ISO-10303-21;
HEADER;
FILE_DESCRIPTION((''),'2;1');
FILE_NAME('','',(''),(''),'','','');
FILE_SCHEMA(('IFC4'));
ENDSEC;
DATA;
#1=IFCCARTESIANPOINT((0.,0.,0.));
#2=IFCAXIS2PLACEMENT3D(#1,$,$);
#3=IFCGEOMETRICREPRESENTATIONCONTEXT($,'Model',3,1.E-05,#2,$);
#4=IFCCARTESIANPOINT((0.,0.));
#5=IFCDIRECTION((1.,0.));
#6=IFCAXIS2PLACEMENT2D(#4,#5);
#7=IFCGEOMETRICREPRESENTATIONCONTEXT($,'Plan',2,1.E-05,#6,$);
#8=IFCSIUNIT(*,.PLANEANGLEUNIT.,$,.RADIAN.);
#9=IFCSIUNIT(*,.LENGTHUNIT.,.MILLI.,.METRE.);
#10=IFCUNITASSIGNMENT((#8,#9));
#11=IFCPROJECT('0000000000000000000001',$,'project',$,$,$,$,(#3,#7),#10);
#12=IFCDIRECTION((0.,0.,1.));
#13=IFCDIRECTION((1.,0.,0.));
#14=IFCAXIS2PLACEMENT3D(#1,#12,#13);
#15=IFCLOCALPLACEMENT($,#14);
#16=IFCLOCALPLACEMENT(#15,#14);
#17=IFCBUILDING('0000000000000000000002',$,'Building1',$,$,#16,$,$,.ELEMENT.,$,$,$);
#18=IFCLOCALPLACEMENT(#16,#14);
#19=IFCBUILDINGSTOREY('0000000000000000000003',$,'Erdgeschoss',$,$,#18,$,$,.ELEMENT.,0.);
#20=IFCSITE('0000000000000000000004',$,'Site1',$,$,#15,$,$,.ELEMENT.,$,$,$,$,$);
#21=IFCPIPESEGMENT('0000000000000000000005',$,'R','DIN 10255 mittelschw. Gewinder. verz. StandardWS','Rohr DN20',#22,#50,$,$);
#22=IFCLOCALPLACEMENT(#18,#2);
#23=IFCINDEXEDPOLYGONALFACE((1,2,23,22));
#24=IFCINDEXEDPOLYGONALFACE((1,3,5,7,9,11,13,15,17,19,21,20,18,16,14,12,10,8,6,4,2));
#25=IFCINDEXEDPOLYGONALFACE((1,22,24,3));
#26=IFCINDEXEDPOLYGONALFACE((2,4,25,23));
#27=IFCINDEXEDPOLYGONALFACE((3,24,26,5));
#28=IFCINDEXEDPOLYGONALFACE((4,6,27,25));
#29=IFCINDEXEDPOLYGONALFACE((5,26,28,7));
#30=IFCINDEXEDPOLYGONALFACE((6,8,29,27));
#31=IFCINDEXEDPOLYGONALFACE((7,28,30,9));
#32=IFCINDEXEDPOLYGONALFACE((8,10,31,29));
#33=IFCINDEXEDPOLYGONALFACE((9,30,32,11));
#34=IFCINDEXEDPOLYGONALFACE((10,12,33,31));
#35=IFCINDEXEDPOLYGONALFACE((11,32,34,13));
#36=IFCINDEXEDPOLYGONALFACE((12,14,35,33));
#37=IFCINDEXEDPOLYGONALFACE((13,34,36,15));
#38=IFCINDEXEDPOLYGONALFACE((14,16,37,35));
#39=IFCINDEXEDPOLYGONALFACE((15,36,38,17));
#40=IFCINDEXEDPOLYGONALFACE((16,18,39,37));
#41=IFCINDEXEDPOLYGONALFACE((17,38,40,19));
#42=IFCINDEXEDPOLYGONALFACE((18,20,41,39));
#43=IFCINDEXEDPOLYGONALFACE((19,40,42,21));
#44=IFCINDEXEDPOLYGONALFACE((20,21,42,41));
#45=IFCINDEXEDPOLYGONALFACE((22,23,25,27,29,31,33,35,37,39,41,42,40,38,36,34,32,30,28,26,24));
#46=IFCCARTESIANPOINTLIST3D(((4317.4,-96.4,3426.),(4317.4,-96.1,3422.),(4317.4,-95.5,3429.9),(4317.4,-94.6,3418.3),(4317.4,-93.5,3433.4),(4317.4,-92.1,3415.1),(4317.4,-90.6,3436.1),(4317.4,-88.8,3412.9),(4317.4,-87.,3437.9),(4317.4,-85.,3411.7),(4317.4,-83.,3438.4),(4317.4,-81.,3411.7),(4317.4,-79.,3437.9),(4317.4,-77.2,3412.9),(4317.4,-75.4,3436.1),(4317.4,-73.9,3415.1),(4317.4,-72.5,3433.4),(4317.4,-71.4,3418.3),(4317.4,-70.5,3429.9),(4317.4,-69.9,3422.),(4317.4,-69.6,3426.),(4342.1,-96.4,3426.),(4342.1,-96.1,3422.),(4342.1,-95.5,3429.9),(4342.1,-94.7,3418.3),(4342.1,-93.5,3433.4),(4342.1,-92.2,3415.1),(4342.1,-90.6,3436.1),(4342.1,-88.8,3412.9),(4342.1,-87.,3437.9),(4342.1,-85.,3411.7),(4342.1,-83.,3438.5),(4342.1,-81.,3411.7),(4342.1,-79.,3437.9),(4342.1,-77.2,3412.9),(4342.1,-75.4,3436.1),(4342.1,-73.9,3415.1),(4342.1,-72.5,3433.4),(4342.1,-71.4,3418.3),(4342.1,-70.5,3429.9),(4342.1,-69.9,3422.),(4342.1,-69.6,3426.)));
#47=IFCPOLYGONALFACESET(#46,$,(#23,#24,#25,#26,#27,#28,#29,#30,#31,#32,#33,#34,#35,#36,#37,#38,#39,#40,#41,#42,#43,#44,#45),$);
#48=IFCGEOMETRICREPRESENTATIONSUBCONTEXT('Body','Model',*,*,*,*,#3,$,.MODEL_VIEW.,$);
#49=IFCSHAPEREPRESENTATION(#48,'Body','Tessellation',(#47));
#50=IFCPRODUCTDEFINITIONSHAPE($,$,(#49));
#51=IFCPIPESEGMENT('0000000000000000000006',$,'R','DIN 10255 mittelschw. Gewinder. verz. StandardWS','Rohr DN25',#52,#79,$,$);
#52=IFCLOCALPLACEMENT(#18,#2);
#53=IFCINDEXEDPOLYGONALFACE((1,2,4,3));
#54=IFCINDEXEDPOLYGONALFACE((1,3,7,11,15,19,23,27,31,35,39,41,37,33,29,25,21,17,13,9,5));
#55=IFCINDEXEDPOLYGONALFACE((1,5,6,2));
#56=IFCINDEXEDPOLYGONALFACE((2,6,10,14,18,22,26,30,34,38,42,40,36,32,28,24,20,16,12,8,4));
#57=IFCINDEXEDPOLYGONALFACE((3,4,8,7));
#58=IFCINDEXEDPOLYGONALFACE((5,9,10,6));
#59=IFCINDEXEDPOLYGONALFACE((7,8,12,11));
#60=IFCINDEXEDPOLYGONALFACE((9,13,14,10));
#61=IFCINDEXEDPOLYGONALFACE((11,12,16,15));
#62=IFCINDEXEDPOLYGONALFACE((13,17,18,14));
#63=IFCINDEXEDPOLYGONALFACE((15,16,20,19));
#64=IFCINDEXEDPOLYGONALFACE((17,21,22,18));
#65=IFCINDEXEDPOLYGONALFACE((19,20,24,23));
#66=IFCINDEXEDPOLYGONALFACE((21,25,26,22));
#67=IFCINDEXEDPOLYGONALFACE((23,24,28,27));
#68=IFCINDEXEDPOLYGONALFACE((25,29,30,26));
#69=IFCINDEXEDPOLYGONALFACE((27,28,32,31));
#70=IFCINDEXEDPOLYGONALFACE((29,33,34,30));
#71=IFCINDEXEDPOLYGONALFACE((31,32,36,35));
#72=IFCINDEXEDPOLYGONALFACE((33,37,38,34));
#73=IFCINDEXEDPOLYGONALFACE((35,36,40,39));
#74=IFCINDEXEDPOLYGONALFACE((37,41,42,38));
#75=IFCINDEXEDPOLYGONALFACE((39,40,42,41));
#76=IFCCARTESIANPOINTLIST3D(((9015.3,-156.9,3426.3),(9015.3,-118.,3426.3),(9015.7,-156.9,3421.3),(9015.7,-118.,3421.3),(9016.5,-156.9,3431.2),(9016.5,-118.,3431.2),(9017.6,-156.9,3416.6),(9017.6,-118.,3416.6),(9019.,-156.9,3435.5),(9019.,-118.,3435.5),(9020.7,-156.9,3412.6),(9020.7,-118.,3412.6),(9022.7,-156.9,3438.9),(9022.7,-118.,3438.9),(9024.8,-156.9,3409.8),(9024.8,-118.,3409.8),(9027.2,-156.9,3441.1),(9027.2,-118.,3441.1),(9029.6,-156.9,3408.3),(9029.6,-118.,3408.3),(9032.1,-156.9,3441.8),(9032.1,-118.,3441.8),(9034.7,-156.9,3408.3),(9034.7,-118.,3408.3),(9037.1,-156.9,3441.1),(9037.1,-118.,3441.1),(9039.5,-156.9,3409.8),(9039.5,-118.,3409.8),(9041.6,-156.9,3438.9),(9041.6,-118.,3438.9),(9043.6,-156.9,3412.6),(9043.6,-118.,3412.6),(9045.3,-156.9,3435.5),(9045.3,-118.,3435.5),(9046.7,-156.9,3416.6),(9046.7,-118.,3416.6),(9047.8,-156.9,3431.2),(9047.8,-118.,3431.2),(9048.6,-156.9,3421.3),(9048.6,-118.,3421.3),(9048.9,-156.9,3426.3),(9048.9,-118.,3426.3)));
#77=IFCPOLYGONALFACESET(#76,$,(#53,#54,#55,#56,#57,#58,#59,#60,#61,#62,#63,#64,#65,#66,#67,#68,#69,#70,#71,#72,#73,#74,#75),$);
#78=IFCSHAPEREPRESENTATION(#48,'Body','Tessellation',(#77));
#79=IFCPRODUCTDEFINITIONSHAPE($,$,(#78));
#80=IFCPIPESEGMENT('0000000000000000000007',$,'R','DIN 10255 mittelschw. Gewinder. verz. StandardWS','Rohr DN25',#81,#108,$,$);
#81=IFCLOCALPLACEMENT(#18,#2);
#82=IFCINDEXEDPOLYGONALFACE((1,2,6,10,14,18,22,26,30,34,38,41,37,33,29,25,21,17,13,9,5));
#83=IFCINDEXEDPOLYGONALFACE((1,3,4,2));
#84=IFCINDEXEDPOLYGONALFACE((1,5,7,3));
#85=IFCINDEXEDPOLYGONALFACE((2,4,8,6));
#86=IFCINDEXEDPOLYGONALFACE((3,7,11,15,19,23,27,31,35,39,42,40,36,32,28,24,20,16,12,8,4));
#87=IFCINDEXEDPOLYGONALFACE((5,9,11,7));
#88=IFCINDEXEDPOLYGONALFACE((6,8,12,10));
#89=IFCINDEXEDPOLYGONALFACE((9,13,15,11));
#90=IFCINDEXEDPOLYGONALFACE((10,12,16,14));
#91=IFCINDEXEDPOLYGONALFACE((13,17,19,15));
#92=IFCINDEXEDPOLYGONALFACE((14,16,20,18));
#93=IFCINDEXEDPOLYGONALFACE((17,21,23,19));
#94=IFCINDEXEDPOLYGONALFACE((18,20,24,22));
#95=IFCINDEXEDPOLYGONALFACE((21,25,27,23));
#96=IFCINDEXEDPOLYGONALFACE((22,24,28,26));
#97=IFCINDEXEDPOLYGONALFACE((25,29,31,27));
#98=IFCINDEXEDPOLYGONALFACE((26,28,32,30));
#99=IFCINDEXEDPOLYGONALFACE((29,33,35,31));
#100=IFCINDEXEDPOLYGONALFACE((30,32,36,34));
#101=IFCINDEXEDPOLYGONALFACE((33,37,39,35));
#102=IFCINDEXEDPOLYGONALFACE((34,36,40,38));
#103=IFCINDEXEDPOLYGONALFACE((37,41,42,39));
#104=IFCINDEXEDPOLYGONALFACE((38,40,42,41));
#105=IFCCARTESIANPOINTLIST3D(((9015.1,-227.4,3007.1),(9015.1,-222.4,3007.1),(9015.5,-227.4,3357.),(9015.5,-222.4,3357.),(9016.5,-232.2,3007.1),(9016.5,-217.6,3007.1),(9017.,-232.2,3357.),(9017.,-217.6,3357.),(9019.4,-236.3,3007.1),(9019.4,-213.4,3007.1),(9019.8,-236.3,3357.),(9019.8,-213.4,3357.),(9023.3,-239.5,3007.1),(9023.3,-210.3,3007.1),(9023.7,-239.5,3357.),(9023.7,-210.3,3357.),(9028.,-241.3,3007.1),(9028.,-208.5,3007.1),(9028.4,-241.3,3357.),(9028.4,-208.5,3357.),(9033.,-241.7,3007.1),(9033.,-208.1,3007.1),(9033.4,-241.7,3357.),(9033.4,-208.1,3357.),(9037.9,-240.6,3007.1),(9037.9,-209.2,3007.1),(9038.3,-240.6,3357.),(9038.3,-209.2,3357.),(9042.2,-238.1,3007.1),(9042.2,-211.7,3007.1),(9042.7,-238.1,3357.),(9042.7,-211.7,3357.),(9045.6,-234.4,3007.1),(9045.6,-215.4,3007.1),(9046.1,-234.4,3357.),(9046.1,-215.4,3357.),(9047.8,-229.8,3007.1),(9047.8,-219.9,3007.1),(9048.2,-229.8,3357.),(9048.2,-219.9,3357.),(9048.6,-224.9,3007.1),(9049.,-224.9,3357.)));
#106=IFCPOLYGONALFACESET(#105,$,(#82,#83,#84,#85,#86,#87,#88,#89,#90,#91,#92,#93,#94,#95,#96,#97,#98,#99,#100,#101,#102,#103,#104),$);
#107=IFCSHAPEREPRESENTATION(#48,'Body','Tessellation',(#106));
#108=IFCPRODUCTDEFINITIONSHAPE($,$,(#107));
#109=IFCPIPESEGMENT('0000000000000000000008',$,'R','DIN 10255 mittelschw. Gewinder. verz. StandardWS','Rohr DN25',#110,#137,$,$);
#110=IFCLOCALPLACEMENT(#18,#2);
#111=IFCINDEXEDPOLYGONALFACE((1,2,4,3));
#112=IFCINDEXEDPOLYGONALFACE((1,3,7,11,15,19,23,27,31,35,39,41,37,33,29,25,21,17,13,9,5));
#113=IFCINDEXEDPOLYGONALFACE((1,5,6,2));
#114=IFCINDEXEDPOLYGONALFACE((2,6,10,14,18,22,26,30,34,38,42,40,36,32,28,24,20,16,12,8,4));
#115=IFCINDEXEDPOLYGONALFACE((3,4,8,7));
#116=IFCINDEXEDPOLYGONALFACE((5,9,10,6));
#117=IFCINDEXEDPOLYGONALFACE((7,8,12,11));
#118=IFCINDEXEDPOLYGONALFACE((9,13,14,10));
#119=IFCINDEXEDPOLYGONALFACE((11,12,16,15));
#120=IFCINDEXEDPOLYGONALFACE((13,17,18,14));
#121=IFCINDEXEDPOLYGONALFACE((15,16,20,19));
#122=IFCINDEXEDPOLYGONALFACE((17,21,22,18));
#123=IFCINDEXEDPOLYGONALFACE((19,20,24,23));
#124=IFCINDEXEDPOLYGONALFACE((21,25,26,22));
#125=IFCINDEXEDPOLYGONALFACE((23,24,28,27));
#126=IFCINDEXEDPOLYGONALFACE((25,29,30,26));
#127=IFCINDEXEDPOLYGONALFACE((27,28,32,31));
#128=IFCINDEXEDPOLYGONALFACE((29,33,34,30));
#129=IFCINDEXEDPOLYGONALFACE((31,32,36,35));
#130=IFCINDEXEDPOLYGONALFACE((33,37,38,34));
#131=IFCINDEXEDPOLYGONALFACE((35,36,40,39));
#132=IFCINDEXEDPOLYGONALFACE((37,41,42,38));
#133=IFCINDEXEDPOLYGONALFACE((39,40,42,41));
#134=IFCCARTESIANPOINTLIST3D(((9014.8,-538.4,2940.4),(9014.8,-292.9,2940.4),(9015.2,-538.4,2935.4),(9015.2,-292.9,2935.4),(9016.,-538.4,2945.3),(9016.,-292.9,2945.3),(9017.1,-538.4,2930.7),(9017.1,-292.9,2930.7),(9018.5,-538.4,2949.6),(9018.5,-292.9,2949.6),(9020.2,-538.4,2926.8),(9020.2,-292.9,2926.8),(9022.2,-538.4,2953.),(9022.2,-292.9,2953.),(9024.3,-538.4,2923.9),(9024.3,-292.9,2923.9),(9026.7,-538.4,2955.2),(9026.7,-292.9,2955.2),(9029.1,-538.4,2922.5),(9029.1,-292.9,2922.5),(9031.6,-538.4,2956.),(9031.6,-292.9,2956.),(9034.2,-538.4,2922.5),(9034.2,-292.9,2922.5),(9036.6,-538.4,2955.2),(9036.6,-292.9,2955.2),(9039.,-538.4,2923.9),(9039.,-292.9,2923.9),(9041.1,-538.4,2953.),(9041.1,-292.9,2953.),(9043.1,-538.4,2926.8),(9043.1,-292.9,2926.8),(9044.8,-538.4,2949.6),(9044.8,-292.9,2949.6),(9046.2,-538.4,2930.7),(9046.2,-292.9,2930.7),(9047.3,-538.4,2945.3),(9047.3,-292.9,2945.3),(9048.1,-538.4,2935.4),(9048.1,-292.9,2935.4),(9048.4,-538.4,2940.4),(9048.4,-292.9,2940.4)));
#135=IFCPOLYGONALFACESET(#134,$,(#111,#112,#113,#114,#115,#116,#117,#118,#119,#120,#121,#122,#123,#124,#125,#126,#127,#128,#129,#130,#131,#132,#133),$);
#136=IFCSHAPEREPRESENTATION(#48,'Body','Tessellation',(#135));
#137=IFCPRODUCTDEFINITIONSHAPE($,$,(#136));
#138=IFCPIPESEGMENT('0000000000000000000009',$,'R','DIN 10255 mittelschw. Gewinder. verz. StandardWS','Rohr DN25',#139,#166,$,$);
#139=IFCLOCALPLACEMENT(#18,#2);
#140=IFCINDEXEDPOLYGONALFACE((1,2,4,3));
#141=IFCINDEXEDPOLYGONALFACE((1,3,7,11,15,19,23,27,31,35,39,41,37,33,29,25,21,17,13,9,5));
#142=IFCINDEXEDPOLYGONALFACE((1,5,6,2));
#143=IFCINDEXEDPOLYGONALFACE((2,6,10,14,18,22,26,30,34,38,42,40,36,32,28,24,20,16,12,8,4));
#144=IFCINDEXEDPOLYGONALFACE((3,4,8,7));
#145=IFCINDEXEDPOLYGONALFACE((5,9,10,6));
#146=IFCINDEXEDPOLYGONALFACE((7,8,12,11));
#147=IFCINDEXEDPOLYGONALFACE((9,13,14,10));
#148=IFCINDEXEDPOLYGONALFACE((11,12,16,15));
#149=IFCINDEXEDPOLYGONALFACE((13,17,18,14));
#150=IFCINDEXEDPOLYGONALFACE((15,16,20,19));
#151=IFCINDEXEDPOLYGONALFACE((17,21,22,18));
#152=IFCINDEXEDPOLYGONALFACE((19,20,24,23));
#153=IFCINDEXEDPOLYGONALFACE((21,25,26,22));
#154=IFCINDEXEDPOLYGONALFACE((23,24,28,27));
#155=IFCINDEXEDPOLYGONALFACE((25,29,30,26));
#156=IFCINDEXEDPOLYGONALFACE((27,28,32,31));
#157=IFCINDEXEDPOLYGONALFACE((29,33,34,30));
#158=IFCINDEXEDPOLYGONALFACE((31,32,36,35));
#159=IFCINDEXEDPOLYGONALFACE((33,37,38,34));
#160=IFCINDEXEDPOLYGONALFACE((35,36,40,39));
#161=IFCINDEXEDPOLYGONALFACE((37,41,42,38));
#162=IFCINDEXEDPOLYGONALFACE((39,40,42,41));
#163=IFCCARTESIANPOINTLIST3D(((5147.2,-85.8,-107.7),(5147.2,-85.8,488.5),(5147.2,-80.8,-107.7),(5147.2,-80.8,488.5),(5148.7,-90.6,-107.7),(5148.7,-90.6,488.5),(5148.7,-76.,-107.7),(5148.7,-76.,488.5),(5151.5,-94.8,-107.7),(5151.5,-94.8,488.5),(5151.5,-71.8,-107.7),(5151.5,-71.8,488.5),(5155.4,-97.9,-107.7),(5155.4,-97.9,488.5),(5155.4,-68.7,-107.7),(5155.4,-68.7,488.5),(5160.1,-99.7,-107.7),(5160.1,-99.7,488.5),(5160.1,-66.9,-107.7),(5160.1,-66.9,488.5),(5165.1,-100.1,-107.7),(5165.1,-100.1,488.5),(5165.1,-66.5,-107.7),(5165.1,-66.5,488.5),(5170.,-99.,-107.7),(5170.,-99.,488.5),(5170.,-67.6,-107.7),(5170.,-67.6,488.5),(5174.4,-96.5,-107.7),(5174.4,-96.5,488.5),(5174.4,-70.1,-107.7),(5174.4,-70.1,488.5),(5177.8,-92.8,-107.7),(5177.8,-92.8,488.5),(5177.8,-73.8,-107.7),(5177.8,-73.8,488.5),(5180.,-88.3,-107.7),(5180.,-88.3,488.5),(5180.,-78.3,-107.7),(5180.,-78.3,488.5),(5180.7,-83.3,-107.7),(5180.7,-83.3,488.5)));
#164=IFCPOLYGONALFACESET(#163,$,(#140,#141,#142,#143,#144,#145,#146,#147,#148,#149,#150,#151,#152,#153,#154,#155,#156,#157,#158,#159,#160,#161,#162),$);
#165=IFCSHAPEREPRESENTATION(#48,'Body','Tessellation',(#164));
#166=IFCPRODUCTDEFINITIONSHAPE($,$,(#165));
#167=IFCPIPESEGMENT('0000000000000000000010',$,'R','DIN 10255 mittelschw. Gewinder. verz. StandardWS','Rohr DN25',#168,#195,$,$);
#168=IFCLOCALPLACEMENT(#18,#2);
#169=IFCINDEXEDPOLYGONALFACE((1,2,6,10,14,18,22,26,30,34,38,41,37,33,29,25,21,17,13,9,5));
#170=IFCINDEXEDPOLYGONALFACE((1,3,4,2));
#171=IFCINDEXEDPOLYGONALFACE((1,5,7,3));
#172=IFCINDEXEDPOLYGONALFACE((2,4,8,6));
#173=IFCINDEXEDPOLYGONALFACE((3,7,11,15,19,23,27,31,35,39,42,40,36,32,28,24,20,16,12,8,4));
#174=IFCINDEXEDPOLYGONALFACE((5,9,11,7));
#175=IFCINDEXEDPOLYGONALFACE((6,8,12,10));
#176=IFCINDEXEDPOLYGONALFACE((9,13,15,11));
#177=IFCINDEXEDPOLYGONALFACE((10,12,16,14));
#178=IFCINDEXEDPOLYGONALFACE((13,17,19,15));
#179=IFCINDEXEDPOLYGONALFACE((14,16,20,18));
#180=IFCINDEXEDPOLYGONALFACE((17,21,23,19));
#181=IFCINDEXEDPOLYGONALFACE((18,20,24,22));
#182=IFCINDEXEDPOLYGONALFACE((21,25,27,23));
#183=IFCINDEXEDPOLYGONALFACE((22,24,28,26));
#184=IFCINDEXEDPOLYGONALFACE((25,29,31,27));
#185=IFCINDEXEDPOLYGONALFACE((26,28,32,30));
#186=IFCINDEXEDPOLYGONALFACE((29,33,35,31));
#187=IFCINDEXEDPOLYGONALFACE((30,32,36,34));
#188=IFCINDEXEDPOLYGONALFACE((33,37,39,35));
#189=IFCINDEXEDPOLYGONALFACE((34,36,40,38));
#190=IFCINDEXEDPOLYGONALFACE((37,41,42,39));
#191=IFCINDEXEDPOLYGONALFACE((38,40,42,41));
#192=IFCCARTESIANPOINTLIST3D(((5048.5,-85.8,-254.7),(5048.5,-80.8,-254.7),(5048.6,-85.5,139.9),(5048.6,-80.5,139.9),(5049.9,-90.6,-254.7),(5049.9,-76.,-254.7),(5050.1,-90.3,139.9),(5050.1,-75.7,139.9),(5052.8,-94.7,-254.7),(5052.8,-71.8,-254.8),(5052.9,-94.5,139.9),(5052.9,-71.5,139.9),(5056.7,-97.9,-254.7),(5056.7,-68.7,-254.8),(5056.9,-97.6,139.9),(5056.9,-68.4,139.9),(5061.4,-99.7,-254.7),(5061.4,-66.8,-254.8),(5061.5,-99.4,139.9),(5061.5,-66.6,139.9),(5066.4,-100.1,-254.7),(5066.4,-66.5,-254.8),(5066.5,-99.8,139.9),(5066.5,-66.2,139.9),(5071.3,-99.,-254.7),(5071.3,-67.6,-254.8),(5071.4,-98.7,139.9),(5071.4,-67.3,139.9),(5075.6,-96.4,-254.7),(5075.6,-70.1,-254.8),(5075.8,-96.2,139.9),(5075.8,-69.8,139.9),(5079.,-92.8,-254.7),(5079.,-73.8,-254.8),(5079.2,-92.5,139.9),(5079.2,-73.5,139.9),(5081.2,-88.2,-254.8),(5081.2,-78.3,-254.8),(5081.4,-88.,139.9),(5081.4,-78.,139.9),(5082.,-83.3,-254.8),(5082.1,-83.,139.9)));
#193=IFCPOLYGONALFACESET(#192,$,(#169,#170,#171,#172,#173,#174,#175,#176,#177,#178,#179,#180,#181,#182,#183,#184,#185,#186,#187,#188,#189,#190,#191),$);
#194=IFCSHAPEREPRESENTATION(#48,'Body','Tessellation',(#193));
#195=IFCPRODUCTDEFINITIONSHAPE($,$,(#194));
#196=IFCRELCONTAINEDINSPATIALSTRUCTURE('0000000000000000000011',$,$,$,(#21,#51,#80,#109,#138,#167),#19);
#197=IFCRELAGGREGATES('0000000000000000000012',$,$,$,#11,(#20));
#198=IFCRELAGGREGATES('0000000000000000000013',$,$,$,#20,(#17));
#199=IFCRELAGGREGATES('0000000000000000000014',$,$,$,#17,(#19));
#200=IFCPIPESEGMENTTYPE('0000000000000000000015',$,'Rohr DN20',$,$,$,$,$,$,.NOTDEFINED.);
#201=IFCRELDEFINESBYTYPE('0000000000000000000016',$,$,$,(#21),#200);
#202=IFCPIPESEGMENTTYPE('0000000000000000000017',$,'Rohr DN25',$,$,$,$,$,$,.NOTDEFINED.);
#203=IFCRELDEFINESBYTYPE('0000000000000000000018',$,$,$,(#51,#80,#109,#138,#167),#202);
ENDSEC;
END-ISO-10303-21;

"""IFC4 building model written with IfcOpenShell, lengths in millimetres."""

from ifc_helpers import new_model, si_unit, frame, origin, origin_with_axes, origin_2d_with_axis, place, context, subcontext, project, spatial, circle, extrude, type_object, element, save


model = new_model("IFC4")

# Units and contexts
model_context = context("Model", 3, precision=1e-05, world=origin())
plan_context = context("Plan", 2, precision=1e-05, world=origin_2d_with_axis())
body_context = subcontext(model_context, "Body", "Model", "MODEL_VIEW")
ifc_project = project(units=[si_unit("PLANEANGLEUNIT", "RADIAN"), si_unit("LENGTHUNIT", "METRE", prefix="MILLI")], contexts=[model_context, plan_context])

# Site, building, storey
site_placement = place(None, origin_with_axes())
site = spatial("IfcSite", under=ifc_project, at=site_placement, Name="Site1", CompositionType="ELEMENT")
building_placement = place(site_placement, origin_with_axes())
building = spatial("IfcBuilding", under=site, at=building_placement, Name="Building1", CompositionType="ELEMENT")
storey_placement = place(building_placement, origin_with_axes())
storey = spatial("IfcBuildingStorey", under=building, at=storey_placement, Name="Erdgeschoss", CompositionType="ELEMENT", Elevation=0.0)

# Pipe segments
pipe_segment_type_1 = type_object("IfcPipeSegmentType", Name="Rohr DN20", PredefinedType="NOTDEFINED")
pipe_segment_1_placement = place(storey_placement, frame((4329.7, -83.2, 3425.0), z_axis=(0.0, 0.0, 1.0), x_axis=(1.0, 0.0, 0.0)))
element("IfcPipeSegment", 1, at=pipe_segment_1_placement, inside=storey, type_object=pipe_segment_type_1, Name="R", Description="DIN 10255 mittelschw. Gewinder. verz. StandardWS", ObjectType="Rohr DN20", context=body_context, shape_type="SolidModel", body=[
    extrude(circle(Radius=13.4, at=origin_2d_with_axis()), frame((12.3, 0.1, 0.0), z_axis=(-1.0, 0.000133, -0.000096), x_axis=(0.0, 0.0, 1.0)), (0.0, 0.0, 1.0), 24.7),
])
pipe_segment_type_2 = type_object("IfcPipeSegmentType", Name="Rohr DN25", PredefinedType="NOTDEFINED")
pipe_segment_2_placement = place(storey_placement, frame((9032.3, -137.4, 3425.0), z_axis=(0.0, 0.0, 1.0), x_axis=(1.0, 0.0, 0.0)))
element("IfcPipeSegment", 2, at=pipe_segment_2_placement, inside=storey, type_object=pipe_segment_type_2, Name="R", Description="DIN 10255 mittelschw. Gewinder. verz. StandardWS", ObjectType="Rohr DN25", context=body_context, shape_type="SolidModel", body=[
    extrude(circle(Radius=16.9, at=origin_2d_with_axis()), frame((-0.1, 19.4, 0.0), z_axis=(0.0, -1.0, 0.0), x_axis=(0.0, 0.0, 1.0)), (0.0, 0.0, 1.0), 38.9),
])
pipe_segment_3_placement = place(storey_placement, frame((9031.9, -225.0, 3182.1), z_axis=(0.0, 0.0, 1.0), x_axis=(1.0, 0.0, 0.0)))
element("IfcPipeSegment", 3, at=pipe_segment_3_placement, inside=storey, type_object=pipe_segment_type_2, Name="R", Description="DIN 10255 mittelschw. Gewinder. verz. StandardWS", ObjectType="Rohr DN25", context=body_context, shape_type="SolidModel", body=[
    extrude(circle(Radius=16.9, at=origin_2d_with_axis()), frame((0.2, 0.2, 174.9), z_axis=(-0.001207, 0.0, -0.999999), x_axis=(1.0, 0.0, 0.0)), (0.0, 0.0, 1.0), 349.9),
])
pipe_segment_4_placement = place(storey_placement, frame((9031.5, -415.6, 2939.1), z_axis=(0.0, 0.0, 1.0), x_axis=(1.0, 0.0, 0.0)))
element("IfcPipeSegment", 4, at=pipe_segment_4_placement, inside=storey, type_object=pipe_segment_type_2, Name="R", Description="DIN 10255 mittelschw. Gewinder. verz. StandardWS", ObjectType="Rohr DN25", context=body_context, shape_type="SolidModel", body=[
    extrude(circle(Radius=16.9, at=origin_2d_with_axis()), frame((0.1, -122.8, 0.0), z_axis=(0.0, 1.0, 0.0), x_axis=(0.0, 0.0, 1.0)), (0.0, 0.0, 1.0), 245.5),
])
pipe_segment_5_placement = place(storey_placement, frame((5163.9, -83.4, 190.4), z_axis=(0.0, 0.0, 1.0), x_axis=(1.0, 0.0, 0.0)))
element("IfcPipeSegment", 5, at=pipe_segment_5_placement, inside=storey, type_object=pipe_segment_type_2, Name="R", Description="DIN 10255 mittelschw. Gewinder. verz. StandardWS", ObjectType="Rohr DN25", context=body_context, shape_type="SolidModel", body=[
    extrude(circle(Radius=16.9, at=origin_2d_with_axis()), frame((0.0, 0.1, -298.1), z_axis=(0.0, 0.0, 1.0), x_axis=(1.0, 0.0, 0.0)), (0.0, 0.0, 1.0), 596.2),
])
pipe_segment_6_placement = place(storey_placement, frame((5065.2, -83.3, -57.4), z_axis=(0.0, 0.0, 1.0), x_axis=(1.0, 0.0, 0.0)))
element("IfcPipeSegment", 6, at=pipe_segment_6_placement, inside=storey, type_object=pipe_segment_type_2, Name="R", Description="DIN 10255 mittelschw. Gewinder. verz. StandardWS", ObjectType="Rohr DN25", context=body_context, shape_type="SolidModel", body=[
    extrude(circle(Radius=16.9, at=origin_2d_with_axis()), frame((-0.1, 0.0, -197.3), z_axis=(0.000425, 0.000703, 1.0), x_axis=(1.0, 0.0, 0.0)), (0.0, 0.0, 1.0), 394.7),
])

save(model, "model.ifc")
